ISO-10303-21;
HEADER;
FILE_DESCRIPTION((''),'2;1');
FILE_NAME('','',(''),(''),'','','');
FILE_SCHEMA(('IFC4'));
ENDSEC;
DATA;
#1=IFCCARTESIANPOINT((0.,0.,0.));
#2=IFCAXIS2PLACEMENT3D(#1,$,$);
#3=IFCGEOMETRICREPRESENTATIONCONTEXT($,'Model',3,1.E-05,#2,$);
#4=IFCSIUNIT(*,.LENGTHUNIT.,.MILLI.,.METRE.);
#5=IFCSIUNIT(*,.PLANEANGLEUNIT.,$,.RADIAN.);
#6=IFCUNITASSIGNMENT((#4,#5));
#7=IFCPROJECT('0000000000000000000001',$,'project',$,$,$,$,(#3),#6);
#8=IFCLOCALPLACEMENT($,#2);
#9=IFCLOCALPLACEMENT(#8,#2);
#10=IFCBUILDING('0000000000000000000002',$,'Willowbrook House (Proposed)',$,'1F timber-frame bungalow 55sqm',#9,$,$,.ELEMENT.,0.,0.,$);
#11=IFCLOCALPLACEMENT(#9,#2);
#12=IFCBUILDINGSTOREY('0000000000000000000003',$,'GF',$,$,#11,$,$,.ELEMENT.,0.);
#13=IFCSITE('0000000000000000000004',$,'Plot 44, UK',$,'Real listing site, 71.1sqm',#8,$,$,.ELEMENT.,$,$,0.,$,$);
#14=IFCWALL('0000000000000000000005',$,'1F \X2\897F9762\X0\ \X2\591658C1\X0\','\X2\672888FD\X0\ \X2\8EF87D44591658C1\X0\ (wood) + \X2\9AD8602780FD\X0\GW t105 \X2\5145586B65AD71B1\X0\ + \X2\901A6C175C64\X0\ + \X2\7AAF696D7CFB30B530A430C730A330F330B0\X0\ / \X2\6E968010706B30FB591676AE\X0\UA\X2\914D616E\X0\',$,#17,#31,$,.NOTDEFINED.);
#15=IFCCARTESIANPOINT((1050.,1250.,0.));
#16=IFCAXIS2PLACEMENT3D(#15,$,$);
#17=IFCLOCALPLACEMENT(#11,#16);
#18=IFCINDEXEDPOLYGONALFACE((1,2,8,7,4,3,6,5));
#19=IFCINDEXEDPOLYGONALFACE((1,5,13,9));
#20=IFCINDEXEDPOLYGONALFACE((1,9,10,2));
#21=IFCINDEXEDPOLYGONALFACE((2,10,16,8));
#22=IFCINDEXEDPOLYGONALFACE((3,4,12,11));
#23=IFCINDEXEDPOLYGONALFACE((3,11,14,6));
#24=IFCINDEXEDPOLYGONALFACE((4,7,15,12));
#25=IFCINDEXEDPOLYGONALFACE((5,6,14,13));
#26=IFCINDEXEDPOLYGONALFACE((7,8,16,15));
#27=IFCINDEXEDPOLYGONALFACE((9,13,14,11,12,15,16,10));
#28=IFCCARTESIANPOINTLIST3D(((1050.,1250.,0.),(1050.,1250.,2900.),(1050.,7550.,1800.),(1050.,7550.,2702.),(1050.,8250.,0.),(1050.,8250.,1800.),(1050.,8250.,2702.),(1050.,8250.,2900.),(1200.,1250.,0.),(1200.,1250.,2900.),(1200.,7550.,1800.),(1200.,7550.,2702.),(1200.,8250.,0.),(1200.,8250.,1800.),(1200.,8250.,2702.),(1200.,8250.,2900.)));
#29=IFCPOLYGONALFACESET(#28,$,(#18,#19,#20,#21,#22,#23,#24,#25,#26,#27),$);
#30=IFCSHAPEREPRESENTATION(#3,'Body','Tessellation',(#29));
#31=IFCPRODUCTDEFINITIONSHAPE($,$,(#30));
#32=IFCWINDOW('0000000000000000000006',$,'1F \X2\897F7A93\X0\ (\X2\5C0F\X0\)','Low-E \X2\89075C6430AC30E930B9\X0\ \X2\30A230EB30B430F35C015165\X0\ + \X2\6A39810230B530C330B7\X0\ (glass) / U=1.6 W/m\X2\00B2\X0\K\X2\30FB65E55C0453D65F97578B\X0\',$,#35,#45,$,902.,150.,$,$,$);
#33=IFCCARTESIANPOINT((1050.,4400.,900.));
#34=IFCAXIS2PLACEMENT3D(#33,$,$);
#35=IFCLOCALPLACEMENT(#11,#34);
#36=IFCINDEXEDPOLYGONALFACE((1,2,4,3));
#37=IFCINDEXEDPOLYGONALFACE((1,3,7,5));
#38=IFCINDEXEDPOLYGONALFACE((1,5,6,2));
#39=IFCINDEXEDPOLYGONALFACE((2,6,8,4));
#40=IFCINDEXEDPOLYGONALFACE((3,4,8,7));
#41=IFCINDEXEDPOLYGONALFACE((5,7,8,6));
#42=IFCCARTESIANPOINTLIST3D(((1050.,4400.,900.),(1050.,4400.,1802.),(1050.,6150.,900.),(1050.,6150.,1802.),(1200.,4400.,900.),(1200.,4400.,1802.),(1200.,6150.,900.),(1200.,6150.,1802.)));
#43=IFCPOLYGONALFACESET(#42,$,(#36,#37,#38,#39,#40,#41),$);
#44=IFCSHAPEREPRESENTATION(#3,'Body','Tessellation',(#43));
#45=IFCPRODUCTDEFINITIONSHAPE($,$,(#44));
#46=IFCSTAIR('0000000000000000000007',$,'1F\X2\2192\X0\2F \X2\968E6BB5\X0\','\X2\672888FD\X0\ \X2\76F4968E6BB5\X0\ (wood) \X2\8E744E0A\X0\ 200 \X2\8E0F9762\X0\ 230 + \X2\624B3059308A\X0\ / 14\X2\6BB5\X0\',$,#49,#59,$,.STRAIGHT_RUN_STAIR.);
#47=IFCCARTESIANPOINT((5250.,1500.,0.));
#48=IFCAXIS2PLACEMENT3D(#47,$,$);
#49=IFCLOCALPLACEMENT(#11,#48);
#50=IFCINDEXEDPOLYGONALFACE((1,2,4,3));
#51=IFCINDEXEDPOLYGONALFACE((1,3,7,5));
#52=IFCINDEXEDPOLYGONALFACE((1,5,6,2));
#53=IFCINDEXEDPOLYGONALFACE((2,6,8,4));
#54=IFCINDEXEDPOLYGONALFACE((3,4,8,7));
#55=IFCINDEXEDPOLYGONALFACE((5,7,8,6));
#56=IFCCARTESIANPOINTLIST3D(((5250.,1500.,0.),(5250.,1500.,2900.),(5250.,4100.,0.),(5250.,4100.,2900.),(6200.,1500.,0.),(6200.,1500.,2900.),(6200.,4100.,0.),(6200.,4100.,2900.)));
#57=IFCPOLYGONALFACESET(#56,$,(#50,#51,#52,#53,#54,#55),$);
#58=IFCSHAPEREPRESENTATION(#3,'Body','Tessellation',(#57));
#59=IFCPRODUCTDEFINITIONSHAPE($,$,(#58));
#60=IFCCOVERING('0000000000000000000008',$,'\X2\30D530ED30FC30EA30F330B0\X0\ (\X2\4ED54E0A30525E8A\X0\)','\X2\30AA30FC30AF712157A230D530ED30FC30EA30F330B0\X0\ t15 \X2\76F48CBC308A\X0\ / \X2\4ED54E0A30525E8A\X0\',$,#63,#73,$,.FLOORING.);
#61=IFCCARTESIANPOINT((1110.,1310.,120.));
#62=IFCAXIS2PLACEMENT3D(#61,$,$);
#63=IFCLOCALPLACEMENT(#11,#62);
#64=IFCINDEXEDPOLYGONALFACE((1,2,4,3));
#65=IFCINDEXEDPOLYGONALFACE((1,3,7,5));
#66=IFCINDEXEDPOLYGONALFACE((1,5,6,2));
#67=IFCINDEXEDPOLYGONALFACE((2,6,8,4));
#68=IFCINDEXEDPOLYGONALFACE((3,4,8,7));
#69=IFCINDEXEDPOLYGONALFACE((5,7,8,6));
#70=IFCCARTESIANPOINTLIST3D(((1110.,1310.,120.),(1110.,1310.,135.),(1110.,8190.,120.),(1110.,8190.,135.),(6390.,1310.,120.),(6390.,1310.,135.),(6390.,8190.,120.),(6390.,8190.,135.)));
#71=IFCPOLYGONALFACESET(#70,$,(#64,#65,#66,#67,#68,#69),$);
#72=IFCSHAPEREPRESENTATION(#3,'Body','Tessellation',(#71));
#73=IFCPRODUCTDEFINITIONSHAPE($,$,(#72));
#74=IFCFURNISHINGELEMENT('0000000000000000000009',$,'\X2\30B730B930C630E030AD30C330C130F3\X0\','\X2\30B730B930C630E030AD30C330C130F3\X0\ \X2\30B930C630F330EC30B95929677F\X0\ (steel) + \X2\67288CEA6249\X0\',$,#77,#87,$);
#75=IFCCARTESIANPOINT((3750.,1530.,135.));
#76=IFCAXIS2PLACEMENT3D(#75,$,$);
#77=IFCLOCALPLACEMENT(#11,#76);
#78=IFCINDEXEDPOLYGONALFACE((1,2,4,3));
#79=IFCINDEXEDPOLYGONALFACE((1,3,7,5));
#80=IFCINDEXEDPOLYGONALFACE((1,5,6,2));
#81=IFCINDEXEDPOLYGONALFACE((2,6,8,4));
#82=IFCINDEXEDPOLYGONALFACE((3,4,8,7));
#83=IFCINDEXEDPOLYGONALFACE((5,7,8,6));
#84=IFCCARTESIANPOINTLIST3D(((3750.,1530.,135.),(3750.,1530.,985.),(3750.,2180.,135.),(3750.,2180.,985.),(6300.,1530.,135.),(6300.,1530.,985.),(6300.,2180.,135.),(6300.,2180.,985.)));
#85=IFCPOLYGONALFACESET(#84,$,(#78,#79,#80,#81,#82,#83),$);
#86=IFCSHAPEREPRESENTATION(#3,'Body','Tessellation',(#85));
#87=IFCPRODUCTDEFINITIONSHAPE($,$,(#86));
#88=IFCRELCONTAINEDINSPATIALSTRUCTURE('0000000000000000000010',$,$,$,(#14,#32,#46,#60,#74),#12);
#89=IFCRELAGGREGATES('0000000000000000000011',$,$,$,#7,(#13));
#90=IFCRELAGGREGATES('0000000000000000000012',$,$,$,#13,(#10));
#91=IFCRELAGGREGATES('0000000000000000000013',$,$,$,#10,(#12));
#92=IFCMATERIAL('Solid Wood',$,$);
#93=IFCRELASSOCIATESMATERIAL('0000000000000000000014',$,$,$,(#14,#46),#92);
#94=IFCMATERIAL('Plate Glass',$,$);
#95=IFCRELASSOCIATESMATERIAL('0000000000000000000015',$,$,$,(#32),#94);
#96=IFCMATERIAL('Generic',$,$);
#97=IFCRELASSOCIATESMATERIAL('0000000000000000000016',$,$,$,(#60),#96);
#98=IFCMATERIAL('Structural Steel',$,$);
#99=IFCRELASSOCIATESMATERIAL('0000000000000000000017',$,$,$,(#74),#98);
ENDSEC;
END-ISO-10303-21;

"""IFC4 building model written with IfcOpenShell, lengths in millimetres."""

from ifc_helpers import new_model, si_unit, frame, frame_2d, origin, place, context, project, spatial, rectangle, extrude, material, element, fill, save


model = new_model("IFC4")

# Units and contexts
model_context = context("Model", 3, precision=1e-05, world=origin())
ifc_project = project(units=[si_unit("LENGTHUNIT", "METRE", prefix="MILLI"), si_unit("PLANEANGLEUNIT", "RADIAN")], contexts=[model_context])

# Site, building, storey
site_placement = place(None, origin())
site = spatial("IfcSite", under=ifc_project, at=site_placement, Name="Plot 44, UK", ObjectType="Real listing site, 71.1sqm", CompositionType="ELEMENT", RefElevation=0.0)
building_placement = place(site_placement, origin())
building = spatial("IfcBuilding", under=site, at=building_placement, Name="Willowbrook House (Proposed)", ObjectType="1F timber-frame bungalow 55sqm", CompositionType="ELEMENT", ElevationOfRefHeight=0.0, ElevationOfTerrain=0.0)
storey_placement = place(building_placement, origin())
storey = spatial("IfcBuildingStorey", under=building, at=storey_placement, Name="GF", CompositionType="ELEMENT", Elevation=0.0)

# Shared definitions
ifc_material_1 = material(Name="Solid Wood")
ifc_material_2 = material(Name="Generic")

# Shared definitions
ifc_material_3 = material(Name="Plate Glass")

# Wall, opening, window
wall_1_placement = place(storey_placement, frame((1050.0, 1250.0, 0.0)))
wall_1 = element("IfcWall", 1, at=wall_1_placement, inside=storey, material=ifc_material_1, Name="1F 西面 外壁", Description="木製 軸組外壁 (wood) + 高性能GW t105 充填断熱 + 通気層 + 窯業系サイディング / 準耐火・外皮UA配慮", PredefinedType="NOTDEFINED", context=model_context, shape_type="SweptSolid", body=[
    extrude(rectangle(XDim=150.0, YDim=7000.0, at=frame_2d((75.0, 3500.0))), frame((1050.0, 1250.0, 0.0)), (0.0, 0.0, 1.0), 2900.0),
])
opening_1_placement = place(storey_placement, frame((1050.0, 4400.0, 900.0)))
opening_1 = element("IfcOpeningElement", 2, at=opening_1_placement, cuts=wall_1, PredefinedType="NOTDEFINED", context=model_context, shape_type="SweptSolid", body=[
    extrude(rectangle(XDim=150.0, YDim=1750.0, at=frame_2d((75.0, 875.0))), frame((1050.0, 4400.0, 900.0)), (0.0, 0.0, 1.0), 902.0),
])
window_1_placement = place(storey_placement, frame((1050.0, 4400.0, 900.0)))
window_1 = element("IfcWindow", 3, at=window_1_placement, inside=storey, material=ifc_material_3, Name="1F 西窓 (小)", Description="Low-E 複層ガラス アルゴン封入 + 樹脂サッシ (glass) / U=1.6 W/m²K・日射取得型", OverallHeight=902.0, OverallWidth=150.0, context=model_context, shape_type="SweptSolid", body=[
    extrude(rectangle(XDim=150.0, YDim=1750.0, at=frame_2d((75.0, 875.0))), frame((1050.0, 4400.0, 900.0)), (0.0, 0.0, 1.0), 902.0),
])
fill(opening_1, window_1)

# Stair
stair_placement = place(storey_placement, frame((5250.0, 1500.0, 0.0)))
element("IfcStair", 4, at=stair_placement, inside=storey, material=ifc_material_1, Name="1F→2F 階段", Description="木製 直階段 (wood) 蹴上 200 踏面 230 + 手すり / 14段", PredefinedType="STRAIGHT_RUN_STAIR", context=model_context, shape_type="SweptSolid", body=[
    extrude(rectangle(XDim=950.0, YDim=2600.0, at=frame_2d((475.0, 1300.0))), frame((5250.0, 1500.0, 0.0)), (0.0, 0.0, 1.0), 2900.0),
])

# Covering
covering_placement = place(storey_placement, frame((1110.0, 1310.0, 120.0)))
element("IfcCovering", 5, at=covering_placement, inside=storey, material=ifc_material_2, Name="フローリング (仕上げ床)", Description="オーク無垢フローリング t15 直貼り / 仕上げ床", PredefinedType="FLOORING", context=model_context, shape_type="SweptSolid", body=[
    extrude(rectangle(XDim=5280.0, YDim=6880.0, at=frame_2d((2640.0, 3440.0))), frame((1110.0, 1310.0, 120.0)), (0.0, 0.0, 1.0), 15.0),
])

# Furnishing element
ifc_material_4 = material(Name="Structural Steel")
furnishing_placement = place(storey_placement, frame((3750.0, 1530.0, 135.0)))
element("IfcFurnishingElement", 6, at=furnishing_placement, inside=storey, material=ifc_material_4, Name="システムキッチン", Description="システムキッチン ステンレス天板 (steel) + 木質扉", context=model_context, shape_type="SweptSolid", body=[
    extrude(rectangle(XDim=2550.0, YDim=650.0, at=frame_2d((1275.0, 325.0))), frame((3750.0, 1530.0, 135.0)), (0.0, 0.0, 1.0), 850.0),
])

save(model, "model.ifc")
